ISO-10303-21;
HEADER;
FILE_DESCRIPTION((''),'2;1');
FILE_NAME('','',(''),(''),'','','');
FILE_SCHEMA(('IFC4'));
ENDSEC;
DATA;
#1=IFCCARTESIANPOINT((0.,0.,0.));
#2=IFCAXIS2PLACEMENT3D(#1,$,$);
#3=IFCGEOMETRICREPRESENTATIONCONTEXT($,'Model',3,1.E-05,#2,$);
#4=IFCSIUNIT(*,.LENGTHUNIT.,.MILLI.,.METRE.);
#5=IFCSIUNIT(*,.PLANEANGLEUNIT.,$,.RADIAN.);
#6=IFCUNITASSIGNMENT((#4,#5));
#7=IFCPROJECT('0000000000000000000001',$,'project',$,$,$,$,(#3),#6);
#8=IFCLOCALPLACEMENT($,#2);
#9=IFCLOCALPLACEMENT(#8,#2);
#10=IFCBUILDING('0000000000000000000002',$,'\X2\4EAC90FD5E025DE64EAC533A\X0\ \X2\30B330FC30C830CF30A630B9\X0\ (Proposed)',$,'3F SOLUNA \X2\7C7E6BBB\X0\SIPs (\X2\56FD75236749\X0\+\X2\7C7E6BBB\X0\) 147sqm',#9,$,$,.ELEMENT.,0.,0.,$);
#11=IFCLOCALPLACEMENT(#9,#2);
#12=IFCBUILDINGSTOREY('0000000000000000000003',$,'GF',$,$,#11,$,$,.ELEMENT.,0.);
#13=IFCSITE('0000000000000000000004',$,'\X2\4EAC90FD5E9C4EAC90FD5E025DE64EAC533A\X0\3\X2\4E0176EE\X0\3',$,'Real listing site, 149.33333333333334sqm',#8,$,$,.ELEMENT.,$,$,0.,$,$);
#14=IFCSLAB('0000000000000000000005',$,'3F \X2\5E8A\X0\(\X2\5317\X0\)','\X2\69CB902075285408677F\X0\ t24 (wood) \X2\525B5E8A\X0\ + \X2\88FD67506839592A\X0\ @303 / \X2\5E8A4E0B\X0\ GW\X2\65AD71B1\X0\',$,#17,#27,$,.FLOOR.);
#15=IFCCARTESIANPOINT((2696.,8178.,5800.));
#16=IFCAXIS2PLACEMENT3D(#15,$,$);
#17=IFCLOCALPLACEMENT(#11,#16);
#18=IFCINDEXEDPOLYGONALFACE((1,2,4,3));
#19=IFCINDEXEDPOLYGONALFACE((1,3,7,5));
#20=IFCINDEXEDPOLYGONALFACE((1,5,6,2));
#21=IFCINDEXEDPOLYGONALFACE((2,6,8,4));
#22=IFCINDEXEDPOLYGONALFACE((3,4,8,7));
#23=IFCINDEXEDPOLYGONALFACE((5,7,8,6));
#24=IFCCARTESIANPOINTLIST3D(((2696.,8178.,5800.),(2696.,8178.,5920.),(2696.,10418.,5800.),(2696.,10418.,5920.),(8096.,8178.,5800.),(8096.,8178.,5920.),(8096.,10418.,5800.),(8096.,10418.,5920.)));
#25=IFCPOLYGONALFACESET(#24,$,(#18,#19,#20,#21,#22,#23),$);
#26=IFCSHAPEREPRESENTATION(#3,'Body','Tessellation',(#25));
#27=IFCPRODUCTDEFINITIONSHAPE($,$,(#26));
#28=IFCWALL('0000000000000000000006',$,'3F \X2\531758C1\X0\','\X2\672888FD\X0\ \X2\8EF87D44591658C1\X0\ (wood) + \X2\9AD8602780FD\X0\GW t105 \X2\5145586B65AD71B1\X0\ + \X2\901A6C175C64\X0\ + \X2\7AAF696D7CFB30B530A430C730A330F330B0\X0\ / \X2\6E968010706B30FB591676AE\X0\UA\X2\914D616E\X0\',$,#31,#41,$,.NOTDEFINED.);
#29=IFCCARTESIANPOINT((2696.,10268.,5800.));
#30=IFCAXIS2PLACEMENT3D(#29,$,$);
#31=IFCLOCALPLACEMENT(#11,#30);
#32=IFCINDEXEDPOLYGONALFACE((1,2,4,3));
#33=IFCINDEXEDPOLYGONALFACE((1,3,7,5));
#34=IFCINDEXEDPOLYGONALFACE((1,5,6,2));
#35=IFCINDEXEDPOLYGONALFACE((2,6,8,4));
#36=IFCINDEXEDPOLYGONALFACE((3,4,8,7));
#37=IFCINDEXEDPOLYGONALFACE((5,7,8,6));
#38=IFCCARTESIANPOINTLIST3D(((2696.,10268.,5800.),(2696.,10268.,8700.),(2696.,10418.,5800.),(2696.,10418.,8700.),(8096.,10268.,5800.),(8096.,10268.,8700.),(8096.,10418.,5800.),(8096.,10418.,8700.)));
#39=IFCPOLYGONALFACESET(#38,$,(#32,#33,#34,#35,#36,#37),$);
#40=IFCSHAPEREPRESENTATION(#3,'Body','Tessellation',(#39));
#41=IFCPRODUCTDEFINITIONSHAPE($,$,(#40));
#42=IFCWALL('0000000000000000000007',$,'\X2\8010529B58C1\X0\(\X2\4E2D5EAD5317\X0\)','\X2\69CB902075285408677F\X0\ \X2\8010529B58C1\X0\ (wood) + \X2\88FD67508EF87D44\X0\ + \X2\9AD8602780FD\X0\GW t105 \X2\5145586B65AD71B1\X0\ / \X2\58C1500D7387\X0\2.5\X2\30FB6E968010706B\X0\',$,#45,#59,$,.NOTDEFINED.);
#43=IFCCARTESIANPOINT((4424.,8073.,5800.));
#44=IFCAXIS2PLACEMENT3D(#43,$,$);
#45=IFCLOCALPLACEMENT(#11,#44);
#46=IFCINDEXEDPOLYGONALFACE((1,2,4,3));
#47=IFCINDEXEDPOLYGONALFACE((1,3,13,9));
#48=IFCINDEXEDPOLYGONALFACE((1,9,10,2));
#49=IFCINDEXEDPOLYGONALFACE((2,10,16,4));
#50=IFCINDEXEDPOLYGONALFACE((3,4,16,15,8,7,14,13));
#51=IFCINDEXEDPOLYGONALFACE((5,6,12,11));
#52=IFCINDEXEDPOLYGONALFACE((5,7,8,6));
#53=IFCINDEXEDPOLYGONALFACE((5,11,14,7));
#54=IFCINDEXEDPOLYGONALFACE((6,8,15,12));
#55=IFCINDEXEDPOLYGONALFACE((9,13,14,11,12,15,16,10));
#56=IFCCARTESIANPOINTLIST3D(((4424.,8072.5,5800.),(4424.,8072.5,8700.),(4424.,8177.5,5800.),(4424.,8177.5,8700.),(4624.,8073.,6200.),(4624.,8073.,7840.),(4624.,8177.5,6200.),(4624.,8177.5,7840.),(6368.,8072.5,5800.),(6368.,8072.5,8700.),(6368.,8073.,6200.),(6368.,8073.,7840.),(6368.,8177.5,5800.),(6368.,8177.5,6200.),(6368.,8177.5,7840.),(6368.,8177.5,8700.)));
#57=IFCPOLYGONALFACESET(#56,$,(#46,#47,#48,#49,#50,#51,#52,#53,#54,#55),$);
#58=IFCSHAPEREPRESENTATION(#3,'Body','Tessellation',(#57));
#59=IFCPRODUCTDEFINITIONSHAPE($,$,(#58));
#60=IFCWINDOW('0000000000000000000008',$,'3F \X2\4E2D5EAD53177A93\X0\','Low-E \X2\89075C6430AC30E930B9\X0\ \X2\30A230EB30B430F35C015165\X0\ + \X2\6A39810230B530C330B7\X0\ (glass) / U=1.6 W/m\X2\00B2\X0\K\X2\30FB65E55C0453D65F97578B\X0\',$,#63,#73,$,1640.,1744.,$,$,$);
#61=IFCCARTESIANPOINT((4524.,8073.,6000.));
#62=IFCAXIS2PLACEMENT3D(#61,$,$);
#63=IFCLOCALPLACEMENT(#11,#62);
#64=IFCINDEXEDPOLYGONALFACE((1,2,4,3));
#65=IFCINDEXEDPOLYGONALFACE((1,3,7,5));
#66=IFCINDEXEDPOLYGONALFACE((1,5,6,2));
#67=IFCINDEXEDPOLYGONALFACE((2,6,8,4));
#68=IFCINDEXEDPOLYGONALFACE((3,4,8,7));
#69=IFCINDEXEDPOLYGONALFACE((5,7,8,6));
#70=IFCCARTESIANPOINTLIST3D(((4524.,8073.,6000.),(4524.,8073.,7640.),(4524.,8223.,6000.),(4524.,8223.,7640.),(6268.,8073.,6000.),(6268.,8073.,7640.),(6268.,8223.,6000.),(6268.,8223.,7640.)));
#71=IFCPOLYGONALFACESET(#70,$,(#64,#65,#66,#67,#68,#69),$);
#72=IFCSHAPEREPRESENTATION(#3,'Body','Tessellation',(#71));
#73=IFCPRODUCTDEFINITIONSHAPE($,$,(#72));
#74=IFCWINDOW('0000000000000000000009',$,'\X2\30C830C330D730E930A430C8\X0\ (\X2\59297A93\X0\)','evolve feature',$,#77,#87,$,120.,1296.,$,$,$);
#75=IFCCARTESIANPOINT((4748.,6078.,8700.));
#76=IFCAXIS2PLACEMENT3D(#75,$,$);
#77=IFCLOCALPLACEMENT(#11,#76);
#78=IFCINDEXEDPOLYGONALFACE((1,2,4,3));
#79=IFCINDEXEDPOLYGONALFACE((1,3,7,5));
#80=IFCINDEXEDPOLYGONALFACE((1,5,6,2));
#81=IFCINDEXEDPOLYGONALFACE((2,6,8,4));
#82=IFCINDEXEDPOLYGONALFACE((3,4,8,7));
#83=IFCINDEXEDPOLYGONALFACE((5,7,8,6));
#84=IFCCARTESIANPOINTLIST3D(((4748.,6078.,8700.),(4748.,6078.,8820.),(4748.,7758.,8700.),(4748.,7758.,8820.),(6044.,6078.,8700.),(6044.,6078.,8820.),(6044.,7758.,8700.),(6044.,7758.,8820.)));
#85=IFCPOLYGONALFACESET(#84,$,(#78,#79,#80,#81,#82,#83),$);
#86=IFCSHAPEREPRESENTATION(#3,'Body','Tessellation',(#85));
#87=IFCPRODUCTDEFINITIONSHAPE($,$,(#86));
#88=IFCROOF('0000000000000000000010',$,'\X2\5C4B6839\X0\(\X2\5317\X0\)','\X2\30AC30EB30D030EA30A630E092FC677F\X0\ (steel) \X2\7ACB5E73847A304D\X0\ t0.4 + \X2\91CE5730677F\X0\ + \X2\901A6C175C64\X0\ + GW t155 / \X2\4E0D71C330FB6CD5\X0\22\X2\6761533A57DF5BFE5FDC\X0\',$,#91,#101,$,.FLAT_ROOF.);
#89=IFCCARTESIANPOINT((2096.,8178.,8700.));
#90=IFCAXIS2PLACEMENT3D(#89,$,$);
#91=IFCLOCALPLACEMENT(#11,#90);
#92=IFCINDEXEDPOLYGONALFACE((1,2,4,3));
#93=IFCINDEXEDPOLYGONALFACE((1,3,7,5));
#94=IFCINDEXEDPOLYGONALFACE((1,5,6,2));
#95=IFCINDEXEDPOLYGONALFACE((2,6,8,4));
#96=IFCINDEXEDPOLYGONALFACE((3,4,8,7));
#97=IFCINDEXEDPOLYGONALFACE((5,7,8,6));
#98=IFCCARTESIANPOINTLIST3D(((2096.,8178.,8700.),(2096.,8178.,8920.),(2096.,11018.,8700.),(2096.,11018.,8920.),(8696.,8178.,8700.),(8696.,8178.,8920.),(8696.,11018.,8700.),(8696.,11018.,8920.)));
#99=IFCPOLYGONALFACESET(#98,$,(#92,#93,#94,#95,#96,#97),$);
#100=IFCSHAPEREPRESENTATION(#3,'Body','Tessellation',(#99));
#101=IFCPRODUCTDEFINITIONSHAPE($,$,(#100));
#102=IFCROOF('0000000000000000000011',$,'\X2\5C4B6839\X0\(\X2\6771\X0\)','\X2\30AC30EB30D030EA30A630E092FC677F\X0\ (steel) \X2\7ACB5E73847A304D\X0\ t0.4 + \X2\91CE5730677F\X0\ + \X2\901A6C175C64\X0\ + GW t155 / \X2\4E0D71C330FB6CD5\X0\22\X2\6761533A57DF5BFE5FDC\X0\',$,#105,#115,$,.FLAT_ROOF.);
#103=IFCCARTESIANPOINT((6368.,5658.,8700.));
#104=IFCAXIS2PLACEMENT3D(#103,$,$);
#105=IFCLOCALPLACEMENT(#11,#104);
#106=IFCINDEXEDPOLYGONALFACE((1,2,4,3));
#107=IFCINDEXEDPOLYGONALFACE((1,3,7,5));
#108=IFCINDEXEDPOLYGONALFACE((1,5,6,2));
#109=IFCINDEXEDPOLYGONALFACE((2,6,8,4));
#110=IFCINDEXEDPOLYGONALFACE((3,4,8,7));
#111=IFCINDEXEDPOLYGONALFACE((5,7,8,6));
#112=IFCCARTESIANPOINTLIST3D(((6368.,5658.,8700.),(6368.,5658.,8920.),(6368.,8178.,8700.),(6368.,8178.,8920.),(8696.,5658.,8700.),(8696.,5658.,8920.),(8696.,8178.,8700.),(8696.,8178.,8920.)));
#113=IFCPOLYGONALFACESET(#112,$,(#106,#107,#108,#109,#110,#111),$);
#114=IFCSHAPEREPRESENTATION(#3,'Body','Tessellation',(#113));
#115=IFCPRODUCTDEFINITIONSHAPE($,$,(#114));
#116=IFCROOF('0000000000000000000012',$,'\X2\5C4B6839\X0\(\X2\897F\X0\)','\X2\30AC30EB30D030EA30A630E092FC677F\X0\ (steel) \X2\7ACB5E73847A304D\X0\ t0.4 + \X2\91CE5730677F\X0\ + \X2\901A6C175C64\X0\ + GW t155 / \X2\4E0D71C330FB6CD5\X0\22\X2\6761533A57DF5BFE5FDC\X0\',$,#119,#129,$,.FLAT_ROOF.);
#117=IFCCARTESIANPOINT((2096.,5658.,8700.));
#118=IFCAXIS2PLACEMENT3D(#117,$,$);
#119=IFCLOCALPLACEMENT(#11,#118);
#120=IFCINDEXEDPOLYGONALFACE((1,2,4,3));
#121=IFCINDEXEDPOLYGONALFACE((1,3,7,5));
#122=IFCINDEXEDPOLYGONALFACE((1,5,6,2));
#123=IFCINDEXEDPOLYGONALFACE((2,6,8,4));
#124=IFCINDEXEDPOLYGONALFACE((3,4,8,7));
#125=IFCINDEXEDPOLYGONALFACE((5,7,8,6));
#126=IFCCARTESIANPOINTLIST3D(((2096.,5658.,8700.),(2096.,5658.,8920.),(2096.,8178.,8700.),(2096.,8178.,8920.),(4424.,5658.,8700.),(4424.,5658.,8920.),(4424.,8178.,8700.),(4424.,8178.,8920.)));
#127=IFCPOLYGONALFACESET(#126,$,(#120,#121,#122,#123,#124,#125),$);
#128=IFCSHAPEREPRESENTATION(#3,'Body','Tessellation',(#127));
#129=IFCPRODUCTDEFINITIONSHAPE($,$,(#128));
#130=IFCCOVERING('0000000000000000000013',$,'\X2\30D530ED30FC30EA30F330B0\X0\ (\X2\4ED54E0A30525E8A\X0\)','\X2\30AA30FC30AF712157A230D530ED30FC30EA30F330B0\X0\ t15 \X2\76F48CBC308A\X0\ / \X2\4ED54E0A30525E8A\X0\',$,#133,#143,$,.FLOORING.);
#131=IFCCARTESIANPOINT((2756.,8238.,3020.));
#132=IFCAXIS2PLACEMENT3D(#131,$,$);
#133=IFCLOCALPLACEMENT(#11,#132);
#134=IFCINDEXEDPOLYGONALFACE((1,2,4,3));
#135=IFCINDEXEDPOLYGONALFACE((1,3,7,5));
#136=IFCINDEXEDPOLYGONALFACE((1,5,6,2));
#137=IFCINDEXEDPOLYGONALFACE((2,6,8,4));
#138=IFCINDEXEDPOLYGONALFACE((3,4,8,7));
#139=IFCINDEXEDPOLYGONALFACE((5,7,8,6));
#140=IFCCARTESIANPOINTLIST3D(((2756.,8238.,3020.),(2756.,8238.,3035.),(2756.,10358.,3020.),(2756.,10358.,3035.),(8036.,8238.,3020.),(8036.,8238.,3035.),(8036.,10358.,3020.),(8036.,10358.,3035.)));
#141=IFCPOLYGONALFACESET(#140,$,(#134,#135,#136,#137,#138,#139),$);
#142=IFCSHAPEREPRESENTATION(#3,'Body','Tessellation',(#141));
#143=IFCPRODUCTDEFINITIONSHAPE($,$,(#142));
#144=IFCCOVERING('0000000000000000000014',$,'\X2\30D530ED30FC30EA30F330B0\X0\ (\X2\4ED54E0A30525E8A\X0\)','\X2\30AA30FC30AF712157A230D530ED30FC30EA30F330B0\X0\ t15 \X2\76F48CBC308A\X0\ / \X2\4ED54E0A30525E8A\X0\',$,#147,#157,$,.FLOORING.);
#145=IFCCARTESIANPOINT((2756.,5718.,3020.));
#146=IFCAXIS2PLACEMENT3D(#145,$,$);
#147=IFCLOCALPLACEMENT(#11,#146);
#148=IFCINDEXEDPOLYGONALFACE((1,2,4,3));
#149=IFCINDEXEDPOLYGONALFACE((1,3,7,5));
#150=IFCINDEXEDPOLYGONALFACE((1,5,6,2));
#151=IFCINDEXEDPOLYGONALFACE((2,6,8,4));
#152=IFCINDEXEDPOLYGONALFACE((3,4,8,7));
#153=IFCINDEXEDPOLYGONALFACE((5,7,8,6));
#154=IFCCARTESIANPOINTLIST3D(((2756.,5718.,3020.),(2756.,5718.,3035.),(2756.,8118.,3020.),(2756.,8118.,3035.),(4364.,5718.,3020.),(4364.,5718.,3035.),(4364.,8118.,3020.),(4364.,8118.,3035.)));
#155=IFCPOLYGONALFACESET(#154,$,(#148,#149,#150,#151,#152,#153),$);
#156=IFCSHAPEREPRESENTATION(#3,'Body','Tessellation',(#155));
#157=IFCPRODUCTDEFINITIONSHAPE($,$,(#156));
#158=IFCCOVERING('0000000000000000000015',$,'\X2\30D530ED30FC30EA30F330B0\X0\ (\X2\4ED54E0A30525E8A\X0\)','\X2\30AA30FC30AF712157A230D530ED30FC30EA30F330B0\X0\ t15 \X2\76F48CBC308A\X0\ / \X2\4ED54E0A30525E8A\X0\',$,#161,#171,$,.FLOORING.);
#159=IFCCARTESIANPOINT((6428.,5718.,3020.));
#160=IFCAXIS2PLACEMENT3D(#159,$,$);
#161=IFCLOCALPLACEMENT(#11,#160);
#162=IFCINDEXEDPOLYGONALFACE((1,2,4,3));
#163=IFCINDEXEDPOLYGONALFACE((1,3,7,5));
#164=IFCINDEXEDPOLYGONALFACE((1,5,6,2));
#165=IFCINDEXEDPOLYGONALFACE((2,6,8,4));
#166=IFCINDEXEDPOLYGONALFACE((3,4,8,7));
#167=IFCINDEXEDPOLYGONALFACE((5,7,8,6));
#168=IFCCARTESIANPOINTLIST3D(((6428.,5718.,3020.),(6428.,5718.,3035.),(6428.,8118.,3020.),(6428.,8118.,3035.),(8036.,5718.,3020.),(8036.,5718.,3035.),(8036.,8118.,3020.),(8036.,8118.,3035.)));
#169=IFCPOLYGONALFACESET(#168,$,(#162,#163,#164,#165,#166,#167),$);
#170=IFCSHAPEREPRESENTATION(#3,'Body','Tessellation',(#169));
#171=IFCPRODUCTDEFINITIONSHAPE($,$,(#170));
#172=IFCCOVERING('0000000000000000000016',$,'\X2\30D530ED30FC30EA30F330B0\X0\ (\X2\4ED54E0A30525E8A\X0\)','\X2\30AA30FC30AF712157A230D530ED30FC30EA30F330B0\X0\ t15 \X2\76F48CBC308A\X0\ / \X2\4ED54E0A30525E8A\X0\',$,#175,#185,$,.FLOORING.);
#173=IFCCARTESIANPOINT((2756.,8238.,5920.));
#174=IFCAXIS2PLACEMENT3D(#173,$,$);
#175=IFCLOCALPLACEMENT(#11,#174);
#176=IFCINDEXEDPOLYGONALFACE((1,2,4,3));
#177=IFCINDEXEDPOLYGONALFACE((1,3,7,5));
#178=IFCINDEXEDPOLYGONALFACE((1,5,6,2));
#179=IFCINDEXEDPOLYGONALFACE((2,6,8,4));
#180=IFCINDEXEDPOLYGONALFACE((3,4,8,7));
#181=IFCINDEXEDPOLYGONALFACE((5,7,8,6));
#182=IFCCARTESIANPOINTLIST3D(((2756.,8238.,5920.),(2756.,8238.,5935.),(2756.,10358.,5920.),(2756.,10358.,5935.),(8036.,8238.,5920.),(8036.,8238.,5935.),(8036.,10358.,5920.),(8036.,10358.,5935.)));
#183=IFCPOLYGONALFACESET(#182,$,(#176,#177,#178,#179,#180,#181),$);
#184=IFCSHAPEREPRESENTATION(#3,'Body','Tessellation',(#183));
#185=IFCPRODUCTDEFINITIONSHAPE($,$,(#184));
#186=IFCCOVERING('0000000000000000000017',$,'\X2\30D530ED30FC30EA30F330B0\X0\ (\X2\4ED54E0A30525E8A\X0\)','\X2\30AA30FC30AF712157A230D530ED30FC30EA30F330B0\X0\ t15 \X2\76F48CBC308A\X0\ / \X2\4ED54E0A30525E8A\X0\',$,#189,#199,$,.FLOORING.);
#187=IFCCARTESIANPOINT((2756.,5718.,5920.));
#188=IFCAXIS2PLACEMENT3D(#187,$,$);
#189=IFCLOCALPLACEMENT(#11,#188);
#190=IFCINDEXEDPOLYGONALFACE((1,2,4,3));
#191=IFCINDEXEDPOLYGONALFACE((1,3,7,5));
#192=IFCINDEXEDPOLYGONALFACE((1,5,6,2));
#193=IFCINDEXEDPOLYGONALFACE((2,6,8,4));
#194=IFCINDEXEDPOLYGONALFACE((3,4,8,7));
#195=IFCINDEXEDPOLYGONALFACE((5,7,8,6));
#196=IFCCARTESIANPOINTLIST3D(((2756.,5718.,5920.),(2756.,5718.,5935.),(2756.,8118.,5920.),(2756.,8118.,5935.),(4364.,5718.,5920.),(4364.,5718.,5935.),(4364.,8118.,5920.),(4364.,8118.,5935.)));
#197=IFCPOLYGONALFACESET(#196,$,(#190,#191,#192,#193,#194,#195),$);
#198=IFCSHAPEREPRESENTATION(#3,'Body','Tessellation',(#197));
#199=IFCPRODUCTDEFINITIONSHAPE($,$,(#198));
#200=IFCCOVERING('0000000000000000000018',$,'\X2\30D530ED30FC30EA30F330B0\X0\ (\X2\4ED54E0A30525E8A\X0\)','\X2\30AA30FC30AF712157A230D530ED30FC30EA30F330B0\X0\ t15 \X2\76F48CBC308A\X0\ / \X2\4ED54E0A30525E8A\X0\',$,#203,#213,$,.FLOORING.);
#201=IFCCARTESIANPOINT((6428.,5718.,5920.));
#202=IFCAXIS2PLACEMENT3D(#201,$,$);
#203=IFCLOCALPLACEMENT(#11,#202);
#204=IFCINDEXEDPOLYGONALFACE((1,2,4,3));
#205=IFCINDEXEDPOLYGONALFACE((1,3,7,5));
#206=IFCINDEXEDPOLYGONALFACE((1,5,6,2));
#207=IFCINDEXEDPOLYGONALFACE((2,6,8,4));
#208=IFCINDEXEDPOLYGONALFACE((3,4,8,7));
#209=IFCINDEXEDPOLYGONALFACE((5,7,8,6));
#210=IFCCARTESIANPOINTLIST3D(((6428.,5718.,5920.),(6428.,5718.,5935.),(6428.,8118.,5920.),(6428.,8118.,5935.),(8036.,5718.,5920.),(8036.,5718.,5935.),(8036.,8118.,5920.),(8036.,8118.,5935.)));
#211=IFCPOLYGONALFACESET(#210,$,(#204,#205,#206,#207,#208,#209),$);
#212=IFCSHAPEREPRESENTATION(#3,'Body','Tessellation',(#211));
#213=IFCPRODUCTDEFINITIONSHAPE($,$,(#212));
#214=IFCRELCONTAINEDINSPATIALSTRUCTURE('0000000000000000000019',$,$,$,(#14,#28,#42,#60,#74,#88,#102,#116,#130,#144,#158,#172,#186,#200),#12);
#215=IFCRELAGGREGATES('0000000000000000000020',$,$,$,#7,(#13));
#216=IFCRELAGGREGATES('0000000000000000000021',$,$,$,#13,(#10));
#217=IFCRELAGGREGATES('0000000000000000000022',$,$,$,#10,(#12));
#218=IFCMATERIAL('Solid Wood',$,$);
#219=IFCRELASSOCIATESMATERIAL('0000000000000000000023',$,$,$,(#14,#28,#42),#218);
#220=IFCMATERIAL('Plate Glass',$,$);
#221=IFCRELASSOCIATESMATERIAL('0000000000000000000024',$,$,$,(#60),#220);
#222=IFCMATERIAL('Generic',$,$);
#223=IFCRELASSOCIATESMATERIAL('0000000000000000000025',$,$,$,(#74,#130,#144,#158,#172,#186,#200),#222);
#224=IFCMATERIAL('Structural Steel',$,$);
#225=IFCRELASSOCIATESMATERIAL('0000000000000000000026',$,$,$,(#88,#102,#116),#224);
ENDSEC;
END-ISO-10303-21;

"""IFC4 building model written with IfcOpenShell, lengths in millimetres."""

from ifc_helpers import new_model, si_unit, frame, frame_2d, origin, place, context, project, spatial, rectangle, extrude, material, element, fill, save


model = new_model("IFC4")

# Units and contexts
model_context = context("Model", 3, precision=1e-05, world=origin())
ifc_project = project(units=[si_unit("LENGTHUNIT", "METRE", prefix="MILLI"), si_unit("PLANEANGLEUNIT", "RADIAN")], contexts=[model_context])

# Site, building, storey
site_placement = place(None, origin())
site = spatial("IfcSite", under=ifc_project, at=site_placement, Name="京都府京都市左京区3丁目3", ObjectType="Real listing site, 149.33333333333334sqm", CompositionType="ELEMENT", RefElevation=0.0)
building_placement = place(site_placement, origin())
building = spatial("IfcBuilding", under=site, at=building_placement, Name="京都市左京区 コートハウス (Proposed)", ObjectType="3F SOLUNA 籾殻SIPs (国産杉+籾殻) 147sqm", CompositionType="ELEMENT", ElevationOfRefHeight=0.0, ElevationOfTerrain=0.0)
storey_placement = place(building_placement, origin())
storey = spatial("IfcBuildingStorey", under=building, at=storey_placement, Name="GF", CompositionType="ELEMENT", Elevation=0.0)

# Slab
ifc_material_1 = material(Name="Solid Wood")
slab_placement = place(storey_placement, frame((2696.0, 8178.0, 5800.0)))
element("IfcSlab", 1, at=slab_placement, inside=storey, material=ifc_material_1, Name="3F 床(北)", Description="構造用合板 t24 (wood) 剛床 + 製材根太 @303 / 床下 GW断熱", PredefinedType="FLOOR", context=model_context, shape_type="SweptSolid", body=[
    extrude(rectangle(XDim=5400.0, YDim=2240.0, at=frame_2d((2700.0, 1120.0))), frame((2696.0, 8178.0, 5800.0)), (0.0, 0.0, 1.0), 120.0),
])

# Wall
wall_1_placement = place(storey_placement, frame((2696.0, 10268.0, 5800.0)))
element("IfcWall", 2, at=wall_1_placement, inside=storey, material=ifc_material_1, Name="3F 北壁", Description="木製 軸組外壁 (wood) + 高性能GW t105 充填断熱 + 通気層 + 窯業系サイディング / 準耐火・外皮UA配慮", PredefinedType="NOTDEFINED", context=model_context, shape_type="SweptSolid", body=[
    extrude(rectangle(XDim=5400.0, YDim=150.0, at=frame_2d((2700.0, 75.0))), frame((2696.0, 10268.0, 5800.0)), (0.0, 0.0, 1.0), 2900.0),
])

# Wall, opening, window
wall_2_placement = place(storey_placement, frame((4424.0, 8073.0, 5800.0)))
wall_2 = element("IfcWall", 3, at=wall_2_placement, inside=storey, material=ifc_material_1, Name="耐力壁(中庭北)", Description="構造用合板 耐力壁 (wood) + 製材軸組 + 高性能GW t105 充填断熱 / 壁倍率2.5・準耐火", PredefinedType="NOTDEFINED", context=model_context, shape_type="SweptSolid", body=[
    extrude(rectangle(XDim=1944.0, YDim=105.0, at=frame_2d((972.0, 52.0))), frame((4424.0, 8073.0, 5800.0)), (0.0, 0.0, 1.0), 2900.0),
])
opening_placement = place(storey_placement, frame((4524.0, 8073.0, 6000.0)))
opening = element("IfcOpeningElement", 4, at=opening_placement, cuts=wall_2, PredefinedType="NOTDEFINED", context=model_context, shape_type="SweptSolid", body=[
    extrude(rectangle(XDim=1744.0, YDim=150.0, at=frame_2d((872.0, 75.0))), frame((4524.0, 8073.0, 6000.0)), (0.0, 0.0, 1.0), 1640.0),
])
ifc_material_2 = material(Name="Plate Glass")
window_1_placement = place(storey_placement, frame((4524.0, 8073.0, 6000.0)))
window_1 = element("IfcWindow", 5, at=window_1_placement, inside=storey, material=ifc_material_2, Name="3F 中庭北窓", Description="Low-E 複層ガラス アルゴン封入 + 樹脂サッシ (glass) / U=1.6 W/m²K・日射取得型", OverallHeight=1640.0, OverallWidth=1744.0, context=model_context, shape_type="SweptSolid", body=[
    extrude(rectangle(XDim=1744.0, YDim=150.0, at=frame_2d((872.0, 75.0))), frame((4524.0, 8073.0, 6000.0)), (0.0, 0.0, 1.0), 1640.0),
])
fill(opening, window_1)

# Window
ifc_material_3 = material(Name="Generic")
window_2_placement = place(storey_placement, frame((4748.0, 6078.0, 8700.0)))
element("IfcWindow", 6, at=window_2_placement, inside=storey, material=ifc_material_3, Name="トップライト (天窓)", Description="evolve feature", OverallHeight=120.0, OverallWidth=1296.0, context=model_context, shape_type="SweptSolid", body=[
    extrude(rectangle(XDim=1296.0, YDim=1680.0, at=frame_2d((648.0, 840.0))), frame((4748.0, 6078.0, 8700.0)), (0.0, 0.0, 1.0), 120.0),
])

# Roofs
ifc_material_4 = material(Name="Structural Steel")
roof_1_placement = place(storey_placement, frame((2096.0, 8178.0, 8700.0)))
element("IfcRoof", 7, at=roof_1_placement, inside=storey, material=ifc_material_4, Name="屋根(北)", Description="ガルバリウム鋼板 (steel) 立平葺き t0.4 + 野地板 + 通気層 + GW t155 / 不燃・法22条区域対応", PredefinedType="FLAT_ROOF", context=model_context, shape_type="SweptSolid", body=[
    extrude(rectangle(XDim=6600.0, YDim=2840.0, at=frame_2d((3300.0, 1420.0))), frame((2096.0, 8178.0, 8700.0)), (0.0, 0.0, 1.0), 220.0),
])
roof_2_placement = place(storey_placement, frame((6368.0, 5658.0, 8700.0)))
element("IfcRoof", 8, at=roof_2_placement, inside=storey, material=ifc_material_4, Name="屋根(東)", Description="ガルバリウム鋼板 (steel) 立平葺き t0.4 + 野地板 + 通気層 + GW t155 / 不燃・法22条区域対応", PredefinedType="FLAT_ROOF", context=model_context, shape_type="SweptSolid", body=[
    extrude(rectangle(XDim=2328.0, YDim=2520.0, at=frame_2d((1164.0, 1260.0))), frame((6368.0, 5658.0, 8700.0)), (0.0, 0.0, 1.0), 220.0),
])
roof_3_placement = place(storey_placement, frame((2096.0, 5658.0, 8700.0)))
element("IfcRoof", 9, at=roof_3_placement, inside=storey, material=ifc_material_4, Name="屋根(西)", Description="ガルバリウム鋼板 (steel) 立平葺き t0.4 + 野地板 + 通気層 + GW t155 / 不燃・法22条区域対応", PredefinedType="FLAT_ROOF", context=model_context, shape_type="SweptSolid", body=[
    extrude(rectangle(XDim=2328.0, YDim=2520.0, at=frame_2d((1164.0, 1260.0))), frame((2096.0, 5658.0, 8700.0)), (0.0, 0.0, 1.0), 220.0),
])

# Coverings
covering_1_placement = place(storey_placement, frame((2756.0, 8238.0, 3020.0)))
element("IfcCovering", 10, at=covering_1_placement, inside=storey, material=ifc_material_3, Name="フローリング (仕上げ床)", Description="オーク無垢フローリング t15 直貼り / 仕上げ床", PredefinedType="FLOORING", context=model_context, shape_type="SweptSolid", body=[
    extrude(rectangle(XDim=5280.0, YDim=2120.0, at=frame_2d((2640.0, 1060.0))), frame((2756.0, 8238.0, 3020.0)), (0.0, 0.0, 1.0), 15.0),
])
covering_2_placement = place(storey_placement, frame((2756.0, 5718.0, 3020.0)))
element("IfcCovering", 11, at=covering_2_placement, inside=storey, material=ifc_material_3, Name="フローリング (仕上げ床)", Description="オーク無垢フローリング t15 直貼り / 仕上げ床", PredefinedType="FLOORING", context=model_context, shape_type="SweptSolid", body=[
    extrude(rectangle(XDim=1608.0, YDim=2400.0, at=frame_2d((804.0, 1200.0))), frame((2756.0, 5718.0, 3020.0)), (0.0, 0.0, 1.0), 15.0),
])
covering_3_placement = place(storey_placement, frame((6428.0, 5718.0, 3020.0)))
element("IfcCovering", 12, at=covering_3_placement, inside=storey, material=ifc_material_3, Name="フローリング (仕上げ床)", Description="オーク無垢フローリング t15 直貼り / 仕上げ床", PredefinedType="FLOORING", context=model_context, shape_type="SweptSolid", body=[
    extrude(rectangle(XDim=1608.0, YDim=2400.0, at=frame_2d((804.0, 1200.0))), frame((6428.0, 5718.0, 3020.0)), (0.0, 0.0, 1.0), 15.0),
])
covering_4_placement = place(storey_placement, frame((2756.0, 8238.0, 5920.0)))
element("IfcCovering", 13, at=covering_4_placement, inside=storey, material=ifc_material_3, Name="フローリング (仕上げ床)", Description="オーク無垢フローリング t15 直貼り / 仕上げ床", PredefinedType="FLOORING", context=model_context, shape_type="SweptSolid", body=[
    extrude(rectangle(XDim=5280.0, YDim=2120.0, at=frame_2d((2640.0, 1060.0))), frame((2756.0, 8238.0, 5920.0)), (0.0, 0.0, 1.0), 15.0),
])
covering_5_placement = place(storey_placement, frame((2756.0, 5718.0, 5920.0)))
element("IfcCovering", 14, at=covering_5_placement, inside=storey, material=ifc_material_3, Name="フローリング (仕上げ床)", Description="オーク無垢フローリング t15 直貼り / 仕上げ床", PredefinedType="FLOORING", context=model_context, shape_type="SweptSolid", body=[
    extrude(rectangle(XDim=1608.0, YDim=2400.0, at=frame_2d((804.0, 1200.0))), frame((2756.0, 5718.0, 5920.0)), (0.0, 0.0, 1.0), 15.0),
])
covering_6_placement = place(storey_placement, frame((6428.0, 5718.0, 5920.0)))
element("IfcCovering", 15, at=covering_6_placement, inside=storey, material=ifc_material_3, Name="フローリング (仕上げ床)", Description="オーク無垢フローリング t15 直貼り / 仕上げ床", PredefinedType="FLOORING", context=model_context, shape_type="SweptSolid", body=[
    extrude(rectangle(XDim=1608.0, YDim=2400.0, at=frame_2d((804.0, 1200.0))), frame((6428.0, 5718.0, 5920.0)), (0.0, 0.0, 1.0), 15.0),
])

save(model, "model.ifc")
